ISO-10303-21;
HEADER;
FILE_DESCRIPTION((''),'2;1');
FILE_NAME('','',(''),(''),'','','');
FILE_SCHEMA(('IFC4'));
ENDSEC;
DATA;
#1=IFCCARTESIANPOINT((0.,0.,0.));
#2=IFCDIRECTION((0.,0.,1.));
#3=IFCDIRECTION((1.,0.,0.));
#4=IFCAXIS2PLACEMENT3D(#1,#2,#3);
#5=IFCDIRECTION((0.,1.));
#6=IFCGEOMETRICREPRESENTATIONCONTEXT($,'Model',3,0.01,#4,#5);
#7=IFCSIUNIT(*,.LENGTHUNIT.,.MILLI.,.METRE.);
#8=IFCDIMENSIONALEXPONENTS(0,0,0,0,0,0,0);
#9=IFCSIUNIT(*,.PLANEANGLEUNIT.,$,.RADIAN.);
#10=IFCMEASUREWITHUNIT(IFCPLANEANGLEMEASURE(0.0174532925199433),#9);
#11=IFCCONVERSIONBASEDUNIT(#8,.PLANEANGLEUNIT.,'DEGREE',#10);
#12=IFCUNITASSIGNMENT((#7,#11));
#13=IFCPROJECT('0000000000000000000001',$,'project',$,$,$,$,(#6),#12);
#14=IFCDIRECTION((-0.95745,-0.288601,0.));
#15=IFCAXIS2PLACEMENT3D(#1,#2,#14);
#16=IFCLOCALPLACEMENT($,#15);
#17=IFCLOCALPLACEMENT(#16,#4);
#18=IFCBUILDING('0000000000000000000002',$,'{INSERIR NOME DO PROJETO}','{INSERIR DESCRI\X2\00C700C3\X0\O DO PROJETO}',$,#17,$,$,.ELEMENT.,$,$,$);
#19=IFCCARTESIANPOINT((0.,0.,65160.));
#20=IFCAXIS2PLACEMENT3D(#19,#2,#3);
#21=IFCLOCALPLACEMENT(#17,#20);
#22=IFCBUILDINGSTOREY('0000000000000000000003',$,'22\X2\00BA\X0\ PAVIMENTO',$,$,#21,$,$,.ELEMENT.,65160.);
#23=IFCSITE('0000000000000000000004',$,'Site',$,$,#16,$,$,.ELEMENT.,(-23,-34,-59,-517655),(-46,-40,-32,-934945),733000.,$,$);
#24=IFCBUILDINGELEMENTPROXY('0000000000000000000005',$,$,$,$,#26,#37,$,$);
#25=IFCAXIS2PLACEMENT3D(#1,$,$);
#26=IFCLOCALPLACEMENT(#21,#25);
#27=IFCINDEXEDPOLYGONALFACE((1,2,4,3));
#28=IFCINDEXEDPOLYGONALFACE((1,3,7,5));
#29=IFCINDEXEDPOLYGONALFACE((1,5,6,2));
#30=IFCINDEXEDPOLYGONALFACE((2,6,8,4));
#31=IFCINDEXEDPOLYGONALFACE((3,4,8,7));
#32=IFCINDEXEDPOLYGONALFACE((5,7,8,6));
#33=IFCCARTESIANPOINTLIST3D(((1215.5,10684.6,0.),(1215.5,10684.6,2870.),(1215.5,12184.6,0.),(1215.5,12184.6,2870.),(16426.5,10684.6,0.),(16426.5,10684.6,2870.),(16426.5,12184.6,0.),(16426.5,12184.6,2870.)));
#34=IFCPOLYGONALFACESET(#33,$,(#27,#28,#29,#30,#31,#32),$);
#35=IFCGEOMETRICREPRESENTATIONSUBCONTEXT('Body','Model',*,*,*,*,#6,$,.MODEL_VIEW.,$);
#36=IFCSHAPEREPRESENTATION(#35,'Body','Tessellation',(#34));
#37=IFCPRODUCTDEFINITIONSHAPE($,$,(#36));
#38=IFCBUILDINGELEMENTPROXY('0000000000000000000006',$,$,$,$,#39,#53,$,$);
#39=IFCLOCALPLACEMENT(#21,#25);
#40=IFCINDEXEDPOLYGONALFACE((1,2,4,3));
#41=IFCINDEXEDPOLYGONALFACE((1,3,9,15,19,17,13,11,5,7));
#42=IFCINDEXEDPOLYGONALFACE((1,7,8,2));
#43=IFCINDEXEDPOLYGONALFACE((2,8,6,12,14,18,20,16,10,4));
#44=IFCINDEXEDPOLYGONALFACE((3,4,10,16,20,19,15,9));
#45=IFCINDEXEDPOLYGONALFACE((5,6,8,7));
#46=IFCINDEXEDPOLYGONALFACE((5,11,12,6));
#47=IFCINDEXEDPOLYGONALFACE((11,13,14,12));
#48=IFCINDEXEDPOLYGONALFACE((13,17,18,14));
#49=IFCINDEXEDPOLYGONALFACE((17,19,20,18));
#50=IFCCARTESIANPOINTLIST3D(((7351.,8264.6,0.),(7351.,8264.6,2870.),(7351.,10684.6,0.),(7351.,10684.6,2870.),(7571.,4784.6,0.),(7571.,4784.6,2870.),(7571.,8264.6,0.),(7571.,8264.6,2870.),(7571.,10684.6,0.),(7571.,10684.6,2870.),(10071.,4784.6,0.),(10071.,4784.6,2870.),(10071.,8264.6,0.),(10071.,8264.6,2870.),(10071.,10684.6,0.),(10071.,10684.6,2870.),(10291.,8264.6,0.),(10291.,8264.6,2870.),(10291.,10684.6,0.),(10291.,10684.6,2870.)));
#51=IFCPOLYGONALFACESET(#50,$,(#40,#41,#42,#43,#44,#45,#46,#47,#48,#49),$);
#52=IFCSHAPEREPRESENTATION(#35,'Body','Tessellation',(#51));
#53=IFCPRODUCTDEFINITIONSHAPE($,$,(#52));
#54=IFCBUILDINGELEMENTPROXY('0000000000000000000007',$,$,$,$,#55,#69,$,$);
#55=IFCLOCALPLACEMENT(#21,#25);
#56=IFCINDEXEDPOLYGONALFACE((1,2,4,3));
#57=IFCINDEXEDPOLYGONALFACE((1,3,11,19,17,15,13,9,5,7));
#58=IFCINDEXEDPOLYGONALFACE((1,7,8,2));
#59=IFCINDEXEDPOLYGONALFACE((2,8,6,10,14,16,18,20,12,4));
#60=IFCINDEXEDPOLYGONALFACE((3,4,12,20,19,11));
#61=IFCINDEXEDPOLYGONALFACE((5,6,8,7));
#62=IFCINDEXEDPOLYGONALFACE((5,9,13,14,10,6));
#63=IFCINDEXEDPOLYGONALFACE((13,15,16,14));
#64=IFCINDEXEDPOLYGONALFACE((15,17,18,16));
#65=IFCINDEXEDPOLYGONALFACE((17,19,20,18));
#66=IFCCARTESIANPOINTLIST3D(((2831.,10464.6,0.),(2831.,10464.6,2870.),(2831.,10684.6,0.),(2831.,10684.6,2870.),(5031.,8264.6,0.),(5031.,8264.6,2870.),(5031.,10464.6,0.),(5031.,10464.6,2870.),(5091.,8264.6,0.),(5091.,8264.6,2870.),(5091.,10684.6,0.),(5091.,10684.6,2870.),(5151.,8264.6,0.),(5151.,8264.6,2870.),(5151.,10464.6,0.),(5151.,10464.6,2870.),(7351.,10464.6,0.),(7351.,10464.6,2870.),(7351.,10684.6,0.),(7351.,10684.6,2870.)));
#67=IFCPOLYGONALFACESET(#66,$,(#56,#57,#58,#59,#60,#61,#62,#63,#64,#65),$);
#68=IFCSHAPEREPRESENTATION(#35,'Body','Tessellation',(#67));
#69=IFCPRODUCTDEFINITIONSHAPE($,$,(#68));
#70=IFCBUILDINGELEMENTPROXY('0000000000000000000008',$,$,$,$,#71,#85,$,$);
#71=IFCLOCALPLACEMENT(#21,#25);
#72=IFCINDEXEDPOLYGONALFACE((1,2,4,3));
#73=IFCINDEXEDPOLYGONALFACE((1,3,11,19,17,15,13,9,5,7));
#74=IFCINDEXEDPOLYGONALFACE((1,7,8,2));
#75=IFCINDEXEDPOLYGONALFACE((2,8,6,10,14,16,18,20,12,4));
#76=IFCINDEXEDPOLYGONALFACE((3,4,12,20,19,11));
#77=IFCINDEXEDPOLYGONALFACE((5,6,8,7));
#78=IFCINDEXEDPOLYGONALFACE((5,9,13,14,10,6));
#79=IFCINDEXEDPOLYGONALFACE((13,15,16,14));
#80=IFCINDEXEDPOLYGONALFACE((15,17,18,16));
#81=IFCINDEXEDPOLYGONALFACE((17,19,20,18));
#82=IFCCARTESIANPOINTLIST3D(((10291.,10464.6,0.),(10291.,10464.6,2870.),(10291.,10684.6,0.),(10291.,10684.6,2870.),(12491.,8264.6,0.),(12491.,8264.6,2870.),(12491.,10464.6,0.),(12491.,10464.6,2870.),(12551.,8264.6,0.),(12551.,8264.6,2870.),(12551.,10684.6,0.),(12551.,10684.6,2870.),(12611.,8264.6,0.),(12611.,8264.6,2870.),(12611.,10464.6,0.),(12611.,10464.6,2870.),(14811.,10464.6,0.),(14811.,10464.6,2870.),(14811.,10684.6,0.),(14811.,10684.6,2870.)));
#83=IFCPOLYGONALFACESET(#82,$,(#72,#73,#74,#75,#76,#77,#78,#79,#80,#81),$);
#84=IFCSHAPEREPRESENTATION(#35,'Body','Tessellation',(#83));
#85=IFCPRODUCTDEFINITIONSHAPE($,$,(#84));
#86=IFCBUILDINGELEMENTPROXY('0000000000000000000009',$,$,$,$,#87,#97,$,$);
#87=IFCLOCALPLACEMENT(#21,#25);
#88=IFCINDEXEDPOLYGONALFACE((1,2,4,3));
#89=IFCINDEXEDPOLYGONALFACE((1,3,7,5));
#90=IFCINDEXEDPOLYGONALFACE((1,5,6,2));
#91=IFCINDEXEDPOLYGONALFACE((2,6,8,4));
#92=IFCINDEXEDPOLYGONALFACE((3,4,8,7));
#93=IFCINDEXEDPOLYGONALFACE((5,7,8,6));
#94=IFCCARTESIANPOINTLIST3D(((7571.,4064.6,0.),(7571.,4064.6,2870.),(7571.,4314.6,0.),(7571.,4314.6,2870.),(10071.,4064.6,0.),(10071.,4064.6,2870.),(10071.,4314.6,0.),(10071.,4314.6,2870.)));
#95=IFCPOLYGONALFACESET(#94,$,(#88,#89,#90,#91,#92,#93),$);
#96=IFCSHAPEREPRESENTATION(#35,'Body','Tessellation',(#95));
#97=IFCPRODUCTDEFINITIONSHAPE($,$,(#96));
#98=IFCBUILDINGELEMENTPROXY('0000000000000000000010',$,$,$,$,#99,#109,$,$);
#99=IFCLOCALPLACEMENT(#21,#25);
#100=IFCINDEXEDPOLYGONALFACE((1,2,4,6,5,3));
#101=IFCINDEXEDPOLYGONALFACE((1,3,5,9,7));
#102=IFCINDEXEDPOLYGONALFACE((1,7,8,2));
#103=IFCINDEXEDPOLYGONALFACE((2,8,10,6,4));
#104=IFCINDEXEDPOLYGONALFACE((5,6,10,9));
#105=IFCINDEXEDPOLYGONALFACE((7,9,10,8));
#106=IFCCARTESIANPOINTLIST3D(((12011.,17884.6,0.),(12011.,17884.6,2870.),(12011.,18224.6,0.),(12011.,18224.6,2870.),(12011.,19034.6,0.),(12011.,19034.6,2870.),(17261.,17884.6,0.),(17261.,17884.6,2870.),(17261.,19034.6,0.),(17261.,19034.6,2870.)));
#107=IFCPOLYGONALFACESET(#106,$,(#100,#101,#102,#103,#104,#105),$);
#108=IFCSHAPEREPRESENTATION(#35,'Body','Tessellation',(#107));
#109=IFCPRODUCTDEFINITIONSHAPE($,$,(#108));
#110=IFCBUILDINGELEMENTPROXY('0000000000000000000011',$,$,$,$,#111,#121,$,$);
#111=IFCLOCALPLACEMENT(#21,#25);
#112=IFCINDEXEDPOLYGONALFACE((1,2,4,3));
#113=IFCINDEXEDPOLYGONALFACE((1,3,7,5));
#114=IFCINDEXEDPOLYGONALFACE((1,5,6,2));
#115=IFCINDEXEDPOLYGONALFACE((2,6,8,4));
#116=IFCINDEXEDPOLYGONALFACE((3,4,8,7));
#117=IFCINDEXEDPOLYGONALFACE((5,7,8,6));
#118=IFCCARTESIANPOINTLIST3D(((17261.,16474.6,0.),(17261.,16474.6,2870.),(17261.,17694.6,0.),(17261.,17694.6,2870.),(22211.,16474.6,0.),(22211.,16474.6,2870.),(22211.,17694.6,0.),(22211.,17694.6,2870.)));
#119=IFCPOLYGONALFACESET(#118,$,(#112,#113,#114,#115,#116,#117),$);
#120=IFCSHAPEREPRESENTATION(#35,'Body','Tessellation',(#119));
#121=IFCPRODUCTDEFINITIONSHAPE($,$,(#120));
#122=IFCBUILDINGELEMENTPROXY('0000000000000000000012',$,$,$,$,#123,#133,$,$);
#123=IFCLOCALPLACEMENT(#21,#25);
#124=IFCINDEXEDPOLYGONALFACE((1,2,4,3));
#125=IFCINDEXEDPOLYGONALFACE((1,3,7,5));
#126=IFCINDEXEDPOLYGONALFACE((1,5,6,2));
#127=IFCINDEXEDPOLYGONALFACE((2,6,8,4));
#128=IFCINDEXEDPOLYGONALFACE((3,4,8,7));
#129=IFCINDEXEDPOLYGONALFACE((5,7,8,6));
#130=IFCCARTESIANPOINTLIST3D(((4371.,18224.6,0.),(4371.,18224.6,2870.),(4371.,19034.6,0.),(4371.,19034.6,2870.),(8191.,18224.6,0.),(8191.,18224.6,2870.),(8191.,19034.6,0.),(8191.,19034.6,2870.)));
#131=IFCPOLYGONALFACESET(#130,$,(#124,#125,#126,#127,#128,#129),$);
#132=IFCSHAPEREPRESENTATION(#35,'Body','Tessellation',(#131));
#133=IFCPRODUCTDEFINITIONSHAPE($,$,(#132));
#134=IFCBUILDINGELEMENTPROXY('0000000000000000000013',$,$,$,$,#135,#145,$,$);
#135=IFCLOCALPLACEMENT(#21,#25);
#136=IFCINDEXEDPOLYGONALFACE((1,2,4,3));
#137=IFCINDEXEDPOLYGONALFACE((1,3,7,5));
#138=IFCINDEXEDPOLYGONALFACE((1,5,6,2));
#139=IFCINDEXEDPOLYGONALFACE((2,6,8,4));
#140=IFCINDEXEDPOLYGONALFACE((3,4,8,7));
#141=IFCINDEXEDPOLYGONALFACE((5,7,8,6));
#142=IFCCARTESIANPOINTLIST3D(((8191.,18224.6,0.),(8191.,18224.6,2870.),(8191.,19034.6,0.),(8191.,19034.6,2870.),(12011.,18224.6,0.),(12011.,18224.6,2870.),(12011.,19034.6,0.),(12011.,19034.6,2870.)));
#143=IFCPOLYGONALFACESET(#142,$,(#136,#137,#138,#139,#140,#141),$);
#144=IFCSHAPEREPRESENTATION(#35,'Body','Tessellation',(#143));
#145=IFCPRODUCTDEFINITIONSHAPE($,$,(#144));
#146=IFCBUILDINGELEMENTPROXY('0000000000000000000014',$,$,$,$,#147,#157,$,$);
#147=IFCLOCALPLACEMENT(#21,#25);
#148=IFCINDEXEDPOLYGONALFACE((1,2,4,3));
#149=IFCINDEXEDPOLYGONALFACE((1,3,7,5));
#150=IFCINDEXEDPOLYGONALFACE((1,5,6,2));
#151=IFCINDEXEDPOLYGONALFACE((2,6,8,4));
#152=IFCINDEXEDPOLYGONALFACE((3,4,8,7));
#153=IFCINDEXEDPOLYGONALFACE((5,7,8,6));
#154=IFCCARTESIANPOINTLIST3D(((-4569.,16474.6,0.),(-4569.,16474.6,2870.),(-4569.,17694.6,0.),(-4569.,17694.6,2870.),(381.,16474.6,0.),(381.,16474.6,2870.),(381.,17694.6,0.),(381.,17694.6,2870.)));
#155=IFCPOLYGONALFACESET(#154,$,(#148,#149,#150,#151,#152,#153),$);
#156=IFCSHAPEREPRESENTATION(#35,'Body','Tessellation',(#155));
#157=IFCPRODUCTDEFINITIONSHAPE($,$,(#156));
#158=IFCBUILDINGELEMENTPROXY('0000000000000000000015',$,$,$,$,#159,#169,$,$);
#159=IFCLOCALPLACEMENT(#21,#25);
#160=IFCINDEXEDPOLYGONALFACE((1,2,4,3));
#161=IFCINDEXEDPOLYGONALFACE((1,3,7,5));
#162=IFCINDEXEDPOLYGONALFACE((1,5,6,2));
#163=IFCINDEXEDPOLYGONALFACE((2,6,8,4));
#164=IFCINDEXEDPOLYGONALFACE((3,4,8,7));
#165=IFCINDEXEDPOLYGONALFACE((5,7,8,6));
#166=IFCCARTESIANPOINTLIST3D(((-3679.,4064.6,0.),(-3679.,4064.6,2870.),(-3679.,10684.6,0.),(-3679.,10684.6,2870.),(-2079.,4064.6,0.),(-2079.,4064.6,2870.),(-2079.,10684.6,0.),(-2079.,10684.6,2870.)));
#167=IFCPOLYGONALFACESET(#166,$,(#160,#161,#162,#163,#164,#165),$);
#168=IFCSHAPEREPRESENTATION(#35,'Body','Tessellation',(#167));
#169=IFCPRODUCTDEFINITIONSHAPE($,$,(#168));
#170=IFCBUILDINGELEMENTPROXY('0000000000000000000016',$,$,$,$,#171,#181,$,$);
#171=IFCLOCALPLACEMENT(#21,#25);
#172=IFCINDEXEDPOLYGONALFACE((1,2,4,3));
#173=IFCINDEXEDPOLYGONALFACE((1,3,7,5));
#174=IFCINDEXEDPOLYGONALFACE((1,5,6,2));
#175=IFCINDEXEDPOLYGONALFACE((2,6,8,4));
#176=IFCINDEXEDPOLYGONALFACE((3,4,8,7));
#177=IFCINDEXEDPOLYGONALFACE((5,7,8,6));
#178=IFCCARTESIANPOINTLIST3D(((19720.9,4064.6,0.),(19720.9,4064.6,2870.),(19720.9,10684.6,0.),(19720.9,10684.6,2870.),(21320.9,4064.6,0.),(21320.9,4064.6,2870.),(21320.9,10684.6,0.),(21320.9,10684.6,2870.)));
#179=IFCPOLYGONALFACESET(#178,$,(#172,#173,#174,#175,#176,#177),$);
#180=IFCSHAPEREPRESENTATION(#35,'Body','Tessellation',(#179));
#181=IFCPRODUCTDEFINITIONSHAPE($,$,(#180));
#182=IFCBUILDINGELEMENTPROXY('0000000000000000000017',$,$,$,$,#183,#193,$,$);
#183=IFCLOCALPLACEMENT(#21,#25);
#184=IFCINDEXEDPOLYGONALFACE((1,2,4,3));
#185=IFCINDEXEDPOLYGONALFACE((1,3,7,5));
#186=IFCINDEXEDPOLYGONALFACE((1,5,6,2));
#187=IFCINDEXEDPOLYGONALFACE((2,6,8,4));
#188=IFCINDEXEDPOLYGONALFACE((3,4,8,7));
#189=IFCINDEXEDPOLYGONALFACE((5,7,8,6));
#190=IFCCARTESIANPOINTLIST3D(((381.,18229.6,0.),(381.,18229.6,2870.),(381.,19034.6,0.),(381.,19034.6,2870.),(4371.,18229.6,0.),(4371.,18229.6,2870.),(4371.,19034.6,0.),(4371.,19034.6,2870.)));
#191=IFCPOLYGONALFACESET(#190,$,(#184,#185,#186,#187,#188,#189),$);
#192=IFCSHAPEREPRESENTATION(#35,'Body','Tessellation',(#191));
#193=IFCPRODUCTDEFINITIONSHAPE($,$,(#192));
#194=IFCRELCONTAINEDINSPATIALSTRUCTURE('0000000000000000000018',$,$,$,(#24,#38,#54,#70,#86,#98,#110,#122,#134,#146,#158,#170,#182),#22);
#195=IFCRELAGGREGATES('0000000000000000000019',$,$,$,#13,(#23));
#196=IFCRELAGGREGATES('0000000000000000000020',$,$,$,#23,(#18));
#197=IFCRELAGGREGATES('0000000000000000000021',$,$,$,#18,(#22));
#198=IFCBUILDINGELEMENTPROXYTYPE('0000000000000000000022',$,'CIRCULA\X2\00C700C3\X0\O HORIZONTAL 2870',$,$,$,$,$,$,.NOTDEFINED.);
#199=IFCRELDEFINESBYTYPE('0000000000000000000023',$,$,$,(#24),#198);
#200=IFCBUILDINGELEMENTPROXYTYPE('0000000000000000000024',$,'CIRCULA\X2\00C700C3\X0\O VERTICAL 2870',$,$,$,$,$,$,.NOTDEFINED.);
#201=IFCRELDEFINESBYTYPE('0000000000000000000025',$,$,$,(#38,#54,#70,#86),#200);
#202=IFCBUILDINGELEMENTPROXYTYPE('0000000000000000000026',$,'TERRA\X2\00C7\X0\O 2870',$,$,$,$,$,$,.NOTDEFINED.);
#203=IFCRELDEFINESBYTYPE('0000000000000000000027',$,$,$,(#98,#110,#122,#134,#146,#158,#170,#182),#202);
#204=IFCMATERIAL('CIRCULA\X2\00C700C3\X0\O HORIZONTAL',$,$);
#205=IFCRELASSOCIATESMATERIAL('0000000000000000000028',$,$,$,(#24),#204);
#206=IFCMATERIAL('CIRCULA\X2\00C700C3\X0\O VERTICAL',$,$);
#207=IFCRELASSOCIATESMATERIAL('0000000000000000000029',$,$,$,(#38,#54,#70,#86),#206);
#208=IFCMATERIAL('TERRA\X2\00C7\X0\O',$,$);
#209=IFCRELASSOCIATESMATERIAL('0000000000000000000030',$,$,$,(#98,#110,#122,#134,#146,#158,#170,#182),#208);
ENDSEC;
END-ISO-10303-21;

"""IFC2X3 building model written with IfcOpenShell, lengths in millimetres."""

from ifc_helpers import new_model, entity, si_unit, converted_unit, direction, frame, origin_with_axes, place, context, subcontext, project, spatial, polyline, outline, extrude, material, type_object, element, save


model = new_model("IFC2X3")

# Units and contexts
model_context = context("Model", 3, precision=0.01, world=origin_with_axes(), true_north=direction((0.0, 1.0)))
body_context = subcontext(model_context, "Body", "Model", "MODEL_VIEW")
ifc_project = project(units=[si_unit("LENGTHUNIT", "METRE", prefix="MILLI"), converted_unit("PLANEANGLEUNIT", "DEGREE", entity("IfcPlaneAngleMeasure", 0.0174532925199433), si_unit("PLANEANGLEUNIT", "RADIAN"), dimensions=[0, 0, 0, 0, 0, 0, 0])], contexts=[model_context])

# Site, building, storey
site_placement = place(None, frame((0.0, 0.0, 0.0), z_axis=(0.0, 0.0, 1.0), x_axis=(-0.95745, -0.288601, 0.0)))
site = spatial("IfcSite", under=ifc_project, at=site_placement, Name="Site", CompositionType="ELEMENT", RefLatitude=(-23, -34, -59, -517655), RefLongitude=(-46, -40, -32, -934945), RefElevation=733000.0)
building_placement = place(site_placement, origin_with_axes())
building = spatial("IfcBuilding", under=site, at=building_placement, Name="{INSERIR NOME DO PROJETO}", Description="{INSERIR DESCRIÇÃO DO PROJETO}", CompositionType="ELEMENT")
storey_placement = place(building_placement, frame((0.0, 0.0, 65160.0), z_axis=(0.0, 0.0, 1.0), x_axis=(1.0, 0.0, 0.0)))
storey = spatial("IfcBuildingStorey", under=building, at=storey_placement, Name="22º PAVIMENTO", CompositionType="ELEMENT", Elevation=65160.0)

# Building element proxies
ifc_material_1 = material(Name="CIRCULAÇÃO HORIZONTAL")
building_element_proxy_type_1 = type_object("IfcBuildingElementProxyType", Name="CIRCULAÇÃO HORIZONTAL 2870", PredefinedType="NOTDEFINED")
proxy_1_placement = place(storey_placement, frame((1215.5, 10684.6, 0.0), z_axis=(0.0, 0.0, 1.0), x_axis=(1.0, 0.0, 0.0)))
element("IfcBuildingElementProxy", 1, at=proxy_1_placement, inside=storey, type_object=building_element_proxy_type_1, material=ifc_material_1, context=body_context, shape_type="SweptSolid", body=[
    extrude(outline(polyline([(0.0, 0.0), (15211.0, 0.0), (15211.0, 1500.0), (0.0, 1500.0), (0.0, 0.0)])), origin_with_axes(), (0.0, 0.0, 1.0), 2870.0),
])
ifc_material_2 = material(Name="CIRCULAÇÃO VERTICAL")
building_element_proxy_type_2 = type_object("IfcBuildingElementProxyType", Name="CIRCULAÇÃO VERTICAL 2870", PredefinedType="NOTDEFINED")
proxy_2_placement = place(storey_placement, frame((7351.0, 10684.6, 0.0), z_axis=(0.0, 0.0, 1.0), x_axis=(1.0, 0.0, 0.0)))
element("IfcBuildingElementProxy", 2, at=proxy_2_placement, inside=storey, type_object=building_element_proxy_type_2, material=ifc_material_2, context=body_context, shape_type="SweptSolid", body=[
    extrude(outline(polyline([(0.0, 0.0), (0.0, -2420.0), (220.0, -2420.0), (220.0, -5900.0), (2720.0, -5900.0), (2720.0, -2420.0), (2940.0, -2420.0), (2940.0, 0.0), (2720.0, 0.0), (220.0, 0.0), (0.0, 0.0)])), origin_with_axes(), (0.0, 0.0, 1.0), 2870.0),
])
proxy_3_placement = place(storey_placement, frame((5091.0, 10684.6, 0.0), z_axis=(0.0, 0.0, 1.0), x_axis=(1.0, 0.0, 0.0)))
element("IfcBuildingElementProxy", 3, at=proxy_3_placement, inside=storey, type_object=building_element_proxy_type_2, material=ifc_material_2, context=body_context, shape_type="SweptSolid", body=[
    extrude(outline(polyline([(0.0, 0.0), (-2260.0, 0.0), (-2260.0, -220.0), (-60.0, -220.0), (-60.0, -2420.0), (0.0, -2420.0), (60.0, -2420.0), (60.0, -220.0), (2260.0, -220.0), (2260.0, 0.0), (0.0, 0.0)])), origin_with_axes(), (0.0, 0.0, 1.0), 2870.0),
])
proxy_4_placement = place(storey_placement, frame((10291.0, 10684.6, 0.0), z_axis=(0.0, 0.0, 1.0), x_axis=(1.0, 0.0, 0.0)))
element("IfcBuildingElementProxy", 4, at=proxy_4_placement, inside=storey, type_object=building_element_proxy_type_2, material=ifc_material_2, context=body_context, shape_type="SweptSolid", body=[
    extrude(outline(polyline([(0.0, 0.0), (0.0, -220.0), (2200.0, -220.0), (2200.0, -2420.0), (2260.0, -2420.0), (2320.0, -2420.0), (2320.0, -220.0), (4520.0, -220.0), (4520.0, 0.0), (2260.0, 0.0), (0.0, 0.0)])), origin_with_axes(), (0.0, 0.0, 1.0), 2870.0),
])
proxy_5_placement = place(storey_placement, frame((7571.0, 4064.6, 0.0), z_axis=(0.0, 0.0, 1.0), x_axis=(1.0, 0.0, 0.0)))
element("IfcBuildingElementProxy", 5, at=proxy_5_placement, inside=storey, type_object=building_element_proxy_type_2, material=ifc_material_2, context=body_context, shape_type="SweptSolid", body=[
    extrude(outline(polyline([(0.0, 0.0), (2500.0, 0.0), (2500.0, 250.0), (0.0, 250.0), (0.0, 0.0)])), origin_with_axes(), (0.0, 0.0, 1.0), 2870.0),
])
ifc_material_3 = material(Name="TERRAÇO")
building_element_proxy_type_3 = type_object("IfcBuildingElementProxyType", Name="TERRAÇO 2870", PredefinedType="NOTDEFINED")
proxy_6_placement = place(storey_placement, frame((12011.0, 19034.6, 0.0), z_axis=(0.0, 0.0, 1.0), x_axis=(1.0, 0.0, 0.0)))
element("IfcBuildingElementProxy", 6, at=proxy_6_placement, inside=storey, type_object=building_element_proxy_type_3, material=ifc_material_3, context=body_context, shape_type="SweptSolid", body=[
    extrude(outline(polyline([(0.0, 0.0), (0.0, -810.0), (0.0, -1150.0), (5250.0, -1150.0), (5250.0, 0.0), (0.0, 0.0)])), origin_with_axes(), (0.0, 0.0, 1.0), 2870.0),
])
proxy_7_placement = place(storey_placement, frame((17261.0, 16474.6, 0.0), z_axis=(0.0, 0.0, 1.0), x_axis=(1.0, 0.0, 0.0)))
element("IfcBuildingElementProxy", 7, at=proxy_7_placement, inside=storey, type_object=building_element_proxy_type_3, material=ifc_material_3, context=body_context, shape_type="SweptSolid", body=[
    extrude(outline(polyline([(0.0, 0.0), (4950.0, 0.0), (4950.0, 1220.0), (0.0, 1220.0), (0.0, 0.0)])), origin_with_axes(), (0.0, 0.0, 1.0), 2870.0),
])
for number, where, z_axis, x_axis in (
    (8, (4371.0, 18224.6, 0.0), (0.0, 0.0, 1.0), (1.0, 0.0, 0.0)),
    (9, (8191.0, 18224.6, 0.0), (0.0, 0.0, 1.0), (1.0, 0.0, 0.0)),
):
    element("IfcBuildingElementProxy", number, at=place(storey_placement, frame(where, z_axis=z_axis, x_axis=x_axis)), inside=storey, type_object=building_element_proxy_type_3, material=ifc_material_3, context=body_context, shape_type="SweptSolid", body=[
        extrude(outline(polyline([(0.0, 0.0), (3820.0, 0.0), (3820.0, 810.0), (0.0, 810.0), (0.0, 0.0)])), origin_with_axes(), (0.0, 0.0, 1.0), 2870.0),
    ])
proxy_8_placement = place(storey_placement, frame((381.0, 17694.6, 0.0), z_axis=(0.0, 0.0, 1.0), x_axis=(1.0, 0.0, 0.0)))
element("IfcBuildingElementProxy", 10, at=proxy_8_placement, inside=storey, type_object=building_element_proxy_type_3, material=ifc_material_3, context=body_context, shape_type="SweptSolid", body=[
    extrude(outline(polyline([(0.0, 0.0), (-4950.0, 0.0), (-4950.0, -1220.0), (0.0, -1220.0), (0.0, 0.0)])), origin_with_axes(), (0.0, 0.0, 1.0), 2870.0),
])
proxy_9_placement = place(storey_placement, frame((-3679.0, 4064.6, 0.0), z_axis=(0.0, 0.0, 1.0), x_axis=(1.0, 0.0, 0.0)))
element("IfcBuildingElementProxy", 11, at=proxy_9_placement, inside=storey, type_object=building_element_proxy_type_3, material=ifc_material_3, context=body_context, shape_type="SweptSolid", body=[
    extrude(outline(polyline([(0.0, 0.0), (1600.0, 0.0), (1600.0, 6620.0), (0.0, 6620.0), (0.0, 0.0)])), origin_with_axes(), (0.0, 0.0, 1.0), 2870.0),
])
proxy_10_placement = place(storey_placement, frame((21320.9, 4064.6, 0.0), z_axis=(0.0, 0.0, 1.0), x_axis=(1.0, 0.0, 0.0)))
element("IfcBuildingElementProxy", 12, at=proxy_10_placement, inside=storey, type_object=building_element_proxy_type_3, material=ifc_material_3, context=body_context, shape_type="SweptSolid", body=[
    extrude(outline(polyline([(0.0, 0.0), (0.0, 6620.0), (-1600.0, 6620.0), (-1600.0, 0.0), (0.0, 0.0)])), origin_with_axes(), (0.0, 0.0, 1.0), 2870.0),
])
proxy_11_placement = place(storey_placement, frame((381.0, 19034.6, 0.0), z_axis=(0.0, 0.0, 1.0), x_axis=(1.0, 0.0, 0.0)))
element("IfcBuildingElementProxy", 13, at=proxy_11_placement, inside=storey, type_object=building_element_proxy_type_3, material=ifc_material_3, context=body_context, shape_type="SweptSolid", body=[
    extrude(outline(polyline([(0.0, 0.0), (0.0, -805.0), (3990.0, -805.0), (3990.0, 0.0), (0.0, 0.0)])), origin_with_axes(), (0.0, 0.0, 1.0), 2870.0),
])

save(model, "model.ifc")
